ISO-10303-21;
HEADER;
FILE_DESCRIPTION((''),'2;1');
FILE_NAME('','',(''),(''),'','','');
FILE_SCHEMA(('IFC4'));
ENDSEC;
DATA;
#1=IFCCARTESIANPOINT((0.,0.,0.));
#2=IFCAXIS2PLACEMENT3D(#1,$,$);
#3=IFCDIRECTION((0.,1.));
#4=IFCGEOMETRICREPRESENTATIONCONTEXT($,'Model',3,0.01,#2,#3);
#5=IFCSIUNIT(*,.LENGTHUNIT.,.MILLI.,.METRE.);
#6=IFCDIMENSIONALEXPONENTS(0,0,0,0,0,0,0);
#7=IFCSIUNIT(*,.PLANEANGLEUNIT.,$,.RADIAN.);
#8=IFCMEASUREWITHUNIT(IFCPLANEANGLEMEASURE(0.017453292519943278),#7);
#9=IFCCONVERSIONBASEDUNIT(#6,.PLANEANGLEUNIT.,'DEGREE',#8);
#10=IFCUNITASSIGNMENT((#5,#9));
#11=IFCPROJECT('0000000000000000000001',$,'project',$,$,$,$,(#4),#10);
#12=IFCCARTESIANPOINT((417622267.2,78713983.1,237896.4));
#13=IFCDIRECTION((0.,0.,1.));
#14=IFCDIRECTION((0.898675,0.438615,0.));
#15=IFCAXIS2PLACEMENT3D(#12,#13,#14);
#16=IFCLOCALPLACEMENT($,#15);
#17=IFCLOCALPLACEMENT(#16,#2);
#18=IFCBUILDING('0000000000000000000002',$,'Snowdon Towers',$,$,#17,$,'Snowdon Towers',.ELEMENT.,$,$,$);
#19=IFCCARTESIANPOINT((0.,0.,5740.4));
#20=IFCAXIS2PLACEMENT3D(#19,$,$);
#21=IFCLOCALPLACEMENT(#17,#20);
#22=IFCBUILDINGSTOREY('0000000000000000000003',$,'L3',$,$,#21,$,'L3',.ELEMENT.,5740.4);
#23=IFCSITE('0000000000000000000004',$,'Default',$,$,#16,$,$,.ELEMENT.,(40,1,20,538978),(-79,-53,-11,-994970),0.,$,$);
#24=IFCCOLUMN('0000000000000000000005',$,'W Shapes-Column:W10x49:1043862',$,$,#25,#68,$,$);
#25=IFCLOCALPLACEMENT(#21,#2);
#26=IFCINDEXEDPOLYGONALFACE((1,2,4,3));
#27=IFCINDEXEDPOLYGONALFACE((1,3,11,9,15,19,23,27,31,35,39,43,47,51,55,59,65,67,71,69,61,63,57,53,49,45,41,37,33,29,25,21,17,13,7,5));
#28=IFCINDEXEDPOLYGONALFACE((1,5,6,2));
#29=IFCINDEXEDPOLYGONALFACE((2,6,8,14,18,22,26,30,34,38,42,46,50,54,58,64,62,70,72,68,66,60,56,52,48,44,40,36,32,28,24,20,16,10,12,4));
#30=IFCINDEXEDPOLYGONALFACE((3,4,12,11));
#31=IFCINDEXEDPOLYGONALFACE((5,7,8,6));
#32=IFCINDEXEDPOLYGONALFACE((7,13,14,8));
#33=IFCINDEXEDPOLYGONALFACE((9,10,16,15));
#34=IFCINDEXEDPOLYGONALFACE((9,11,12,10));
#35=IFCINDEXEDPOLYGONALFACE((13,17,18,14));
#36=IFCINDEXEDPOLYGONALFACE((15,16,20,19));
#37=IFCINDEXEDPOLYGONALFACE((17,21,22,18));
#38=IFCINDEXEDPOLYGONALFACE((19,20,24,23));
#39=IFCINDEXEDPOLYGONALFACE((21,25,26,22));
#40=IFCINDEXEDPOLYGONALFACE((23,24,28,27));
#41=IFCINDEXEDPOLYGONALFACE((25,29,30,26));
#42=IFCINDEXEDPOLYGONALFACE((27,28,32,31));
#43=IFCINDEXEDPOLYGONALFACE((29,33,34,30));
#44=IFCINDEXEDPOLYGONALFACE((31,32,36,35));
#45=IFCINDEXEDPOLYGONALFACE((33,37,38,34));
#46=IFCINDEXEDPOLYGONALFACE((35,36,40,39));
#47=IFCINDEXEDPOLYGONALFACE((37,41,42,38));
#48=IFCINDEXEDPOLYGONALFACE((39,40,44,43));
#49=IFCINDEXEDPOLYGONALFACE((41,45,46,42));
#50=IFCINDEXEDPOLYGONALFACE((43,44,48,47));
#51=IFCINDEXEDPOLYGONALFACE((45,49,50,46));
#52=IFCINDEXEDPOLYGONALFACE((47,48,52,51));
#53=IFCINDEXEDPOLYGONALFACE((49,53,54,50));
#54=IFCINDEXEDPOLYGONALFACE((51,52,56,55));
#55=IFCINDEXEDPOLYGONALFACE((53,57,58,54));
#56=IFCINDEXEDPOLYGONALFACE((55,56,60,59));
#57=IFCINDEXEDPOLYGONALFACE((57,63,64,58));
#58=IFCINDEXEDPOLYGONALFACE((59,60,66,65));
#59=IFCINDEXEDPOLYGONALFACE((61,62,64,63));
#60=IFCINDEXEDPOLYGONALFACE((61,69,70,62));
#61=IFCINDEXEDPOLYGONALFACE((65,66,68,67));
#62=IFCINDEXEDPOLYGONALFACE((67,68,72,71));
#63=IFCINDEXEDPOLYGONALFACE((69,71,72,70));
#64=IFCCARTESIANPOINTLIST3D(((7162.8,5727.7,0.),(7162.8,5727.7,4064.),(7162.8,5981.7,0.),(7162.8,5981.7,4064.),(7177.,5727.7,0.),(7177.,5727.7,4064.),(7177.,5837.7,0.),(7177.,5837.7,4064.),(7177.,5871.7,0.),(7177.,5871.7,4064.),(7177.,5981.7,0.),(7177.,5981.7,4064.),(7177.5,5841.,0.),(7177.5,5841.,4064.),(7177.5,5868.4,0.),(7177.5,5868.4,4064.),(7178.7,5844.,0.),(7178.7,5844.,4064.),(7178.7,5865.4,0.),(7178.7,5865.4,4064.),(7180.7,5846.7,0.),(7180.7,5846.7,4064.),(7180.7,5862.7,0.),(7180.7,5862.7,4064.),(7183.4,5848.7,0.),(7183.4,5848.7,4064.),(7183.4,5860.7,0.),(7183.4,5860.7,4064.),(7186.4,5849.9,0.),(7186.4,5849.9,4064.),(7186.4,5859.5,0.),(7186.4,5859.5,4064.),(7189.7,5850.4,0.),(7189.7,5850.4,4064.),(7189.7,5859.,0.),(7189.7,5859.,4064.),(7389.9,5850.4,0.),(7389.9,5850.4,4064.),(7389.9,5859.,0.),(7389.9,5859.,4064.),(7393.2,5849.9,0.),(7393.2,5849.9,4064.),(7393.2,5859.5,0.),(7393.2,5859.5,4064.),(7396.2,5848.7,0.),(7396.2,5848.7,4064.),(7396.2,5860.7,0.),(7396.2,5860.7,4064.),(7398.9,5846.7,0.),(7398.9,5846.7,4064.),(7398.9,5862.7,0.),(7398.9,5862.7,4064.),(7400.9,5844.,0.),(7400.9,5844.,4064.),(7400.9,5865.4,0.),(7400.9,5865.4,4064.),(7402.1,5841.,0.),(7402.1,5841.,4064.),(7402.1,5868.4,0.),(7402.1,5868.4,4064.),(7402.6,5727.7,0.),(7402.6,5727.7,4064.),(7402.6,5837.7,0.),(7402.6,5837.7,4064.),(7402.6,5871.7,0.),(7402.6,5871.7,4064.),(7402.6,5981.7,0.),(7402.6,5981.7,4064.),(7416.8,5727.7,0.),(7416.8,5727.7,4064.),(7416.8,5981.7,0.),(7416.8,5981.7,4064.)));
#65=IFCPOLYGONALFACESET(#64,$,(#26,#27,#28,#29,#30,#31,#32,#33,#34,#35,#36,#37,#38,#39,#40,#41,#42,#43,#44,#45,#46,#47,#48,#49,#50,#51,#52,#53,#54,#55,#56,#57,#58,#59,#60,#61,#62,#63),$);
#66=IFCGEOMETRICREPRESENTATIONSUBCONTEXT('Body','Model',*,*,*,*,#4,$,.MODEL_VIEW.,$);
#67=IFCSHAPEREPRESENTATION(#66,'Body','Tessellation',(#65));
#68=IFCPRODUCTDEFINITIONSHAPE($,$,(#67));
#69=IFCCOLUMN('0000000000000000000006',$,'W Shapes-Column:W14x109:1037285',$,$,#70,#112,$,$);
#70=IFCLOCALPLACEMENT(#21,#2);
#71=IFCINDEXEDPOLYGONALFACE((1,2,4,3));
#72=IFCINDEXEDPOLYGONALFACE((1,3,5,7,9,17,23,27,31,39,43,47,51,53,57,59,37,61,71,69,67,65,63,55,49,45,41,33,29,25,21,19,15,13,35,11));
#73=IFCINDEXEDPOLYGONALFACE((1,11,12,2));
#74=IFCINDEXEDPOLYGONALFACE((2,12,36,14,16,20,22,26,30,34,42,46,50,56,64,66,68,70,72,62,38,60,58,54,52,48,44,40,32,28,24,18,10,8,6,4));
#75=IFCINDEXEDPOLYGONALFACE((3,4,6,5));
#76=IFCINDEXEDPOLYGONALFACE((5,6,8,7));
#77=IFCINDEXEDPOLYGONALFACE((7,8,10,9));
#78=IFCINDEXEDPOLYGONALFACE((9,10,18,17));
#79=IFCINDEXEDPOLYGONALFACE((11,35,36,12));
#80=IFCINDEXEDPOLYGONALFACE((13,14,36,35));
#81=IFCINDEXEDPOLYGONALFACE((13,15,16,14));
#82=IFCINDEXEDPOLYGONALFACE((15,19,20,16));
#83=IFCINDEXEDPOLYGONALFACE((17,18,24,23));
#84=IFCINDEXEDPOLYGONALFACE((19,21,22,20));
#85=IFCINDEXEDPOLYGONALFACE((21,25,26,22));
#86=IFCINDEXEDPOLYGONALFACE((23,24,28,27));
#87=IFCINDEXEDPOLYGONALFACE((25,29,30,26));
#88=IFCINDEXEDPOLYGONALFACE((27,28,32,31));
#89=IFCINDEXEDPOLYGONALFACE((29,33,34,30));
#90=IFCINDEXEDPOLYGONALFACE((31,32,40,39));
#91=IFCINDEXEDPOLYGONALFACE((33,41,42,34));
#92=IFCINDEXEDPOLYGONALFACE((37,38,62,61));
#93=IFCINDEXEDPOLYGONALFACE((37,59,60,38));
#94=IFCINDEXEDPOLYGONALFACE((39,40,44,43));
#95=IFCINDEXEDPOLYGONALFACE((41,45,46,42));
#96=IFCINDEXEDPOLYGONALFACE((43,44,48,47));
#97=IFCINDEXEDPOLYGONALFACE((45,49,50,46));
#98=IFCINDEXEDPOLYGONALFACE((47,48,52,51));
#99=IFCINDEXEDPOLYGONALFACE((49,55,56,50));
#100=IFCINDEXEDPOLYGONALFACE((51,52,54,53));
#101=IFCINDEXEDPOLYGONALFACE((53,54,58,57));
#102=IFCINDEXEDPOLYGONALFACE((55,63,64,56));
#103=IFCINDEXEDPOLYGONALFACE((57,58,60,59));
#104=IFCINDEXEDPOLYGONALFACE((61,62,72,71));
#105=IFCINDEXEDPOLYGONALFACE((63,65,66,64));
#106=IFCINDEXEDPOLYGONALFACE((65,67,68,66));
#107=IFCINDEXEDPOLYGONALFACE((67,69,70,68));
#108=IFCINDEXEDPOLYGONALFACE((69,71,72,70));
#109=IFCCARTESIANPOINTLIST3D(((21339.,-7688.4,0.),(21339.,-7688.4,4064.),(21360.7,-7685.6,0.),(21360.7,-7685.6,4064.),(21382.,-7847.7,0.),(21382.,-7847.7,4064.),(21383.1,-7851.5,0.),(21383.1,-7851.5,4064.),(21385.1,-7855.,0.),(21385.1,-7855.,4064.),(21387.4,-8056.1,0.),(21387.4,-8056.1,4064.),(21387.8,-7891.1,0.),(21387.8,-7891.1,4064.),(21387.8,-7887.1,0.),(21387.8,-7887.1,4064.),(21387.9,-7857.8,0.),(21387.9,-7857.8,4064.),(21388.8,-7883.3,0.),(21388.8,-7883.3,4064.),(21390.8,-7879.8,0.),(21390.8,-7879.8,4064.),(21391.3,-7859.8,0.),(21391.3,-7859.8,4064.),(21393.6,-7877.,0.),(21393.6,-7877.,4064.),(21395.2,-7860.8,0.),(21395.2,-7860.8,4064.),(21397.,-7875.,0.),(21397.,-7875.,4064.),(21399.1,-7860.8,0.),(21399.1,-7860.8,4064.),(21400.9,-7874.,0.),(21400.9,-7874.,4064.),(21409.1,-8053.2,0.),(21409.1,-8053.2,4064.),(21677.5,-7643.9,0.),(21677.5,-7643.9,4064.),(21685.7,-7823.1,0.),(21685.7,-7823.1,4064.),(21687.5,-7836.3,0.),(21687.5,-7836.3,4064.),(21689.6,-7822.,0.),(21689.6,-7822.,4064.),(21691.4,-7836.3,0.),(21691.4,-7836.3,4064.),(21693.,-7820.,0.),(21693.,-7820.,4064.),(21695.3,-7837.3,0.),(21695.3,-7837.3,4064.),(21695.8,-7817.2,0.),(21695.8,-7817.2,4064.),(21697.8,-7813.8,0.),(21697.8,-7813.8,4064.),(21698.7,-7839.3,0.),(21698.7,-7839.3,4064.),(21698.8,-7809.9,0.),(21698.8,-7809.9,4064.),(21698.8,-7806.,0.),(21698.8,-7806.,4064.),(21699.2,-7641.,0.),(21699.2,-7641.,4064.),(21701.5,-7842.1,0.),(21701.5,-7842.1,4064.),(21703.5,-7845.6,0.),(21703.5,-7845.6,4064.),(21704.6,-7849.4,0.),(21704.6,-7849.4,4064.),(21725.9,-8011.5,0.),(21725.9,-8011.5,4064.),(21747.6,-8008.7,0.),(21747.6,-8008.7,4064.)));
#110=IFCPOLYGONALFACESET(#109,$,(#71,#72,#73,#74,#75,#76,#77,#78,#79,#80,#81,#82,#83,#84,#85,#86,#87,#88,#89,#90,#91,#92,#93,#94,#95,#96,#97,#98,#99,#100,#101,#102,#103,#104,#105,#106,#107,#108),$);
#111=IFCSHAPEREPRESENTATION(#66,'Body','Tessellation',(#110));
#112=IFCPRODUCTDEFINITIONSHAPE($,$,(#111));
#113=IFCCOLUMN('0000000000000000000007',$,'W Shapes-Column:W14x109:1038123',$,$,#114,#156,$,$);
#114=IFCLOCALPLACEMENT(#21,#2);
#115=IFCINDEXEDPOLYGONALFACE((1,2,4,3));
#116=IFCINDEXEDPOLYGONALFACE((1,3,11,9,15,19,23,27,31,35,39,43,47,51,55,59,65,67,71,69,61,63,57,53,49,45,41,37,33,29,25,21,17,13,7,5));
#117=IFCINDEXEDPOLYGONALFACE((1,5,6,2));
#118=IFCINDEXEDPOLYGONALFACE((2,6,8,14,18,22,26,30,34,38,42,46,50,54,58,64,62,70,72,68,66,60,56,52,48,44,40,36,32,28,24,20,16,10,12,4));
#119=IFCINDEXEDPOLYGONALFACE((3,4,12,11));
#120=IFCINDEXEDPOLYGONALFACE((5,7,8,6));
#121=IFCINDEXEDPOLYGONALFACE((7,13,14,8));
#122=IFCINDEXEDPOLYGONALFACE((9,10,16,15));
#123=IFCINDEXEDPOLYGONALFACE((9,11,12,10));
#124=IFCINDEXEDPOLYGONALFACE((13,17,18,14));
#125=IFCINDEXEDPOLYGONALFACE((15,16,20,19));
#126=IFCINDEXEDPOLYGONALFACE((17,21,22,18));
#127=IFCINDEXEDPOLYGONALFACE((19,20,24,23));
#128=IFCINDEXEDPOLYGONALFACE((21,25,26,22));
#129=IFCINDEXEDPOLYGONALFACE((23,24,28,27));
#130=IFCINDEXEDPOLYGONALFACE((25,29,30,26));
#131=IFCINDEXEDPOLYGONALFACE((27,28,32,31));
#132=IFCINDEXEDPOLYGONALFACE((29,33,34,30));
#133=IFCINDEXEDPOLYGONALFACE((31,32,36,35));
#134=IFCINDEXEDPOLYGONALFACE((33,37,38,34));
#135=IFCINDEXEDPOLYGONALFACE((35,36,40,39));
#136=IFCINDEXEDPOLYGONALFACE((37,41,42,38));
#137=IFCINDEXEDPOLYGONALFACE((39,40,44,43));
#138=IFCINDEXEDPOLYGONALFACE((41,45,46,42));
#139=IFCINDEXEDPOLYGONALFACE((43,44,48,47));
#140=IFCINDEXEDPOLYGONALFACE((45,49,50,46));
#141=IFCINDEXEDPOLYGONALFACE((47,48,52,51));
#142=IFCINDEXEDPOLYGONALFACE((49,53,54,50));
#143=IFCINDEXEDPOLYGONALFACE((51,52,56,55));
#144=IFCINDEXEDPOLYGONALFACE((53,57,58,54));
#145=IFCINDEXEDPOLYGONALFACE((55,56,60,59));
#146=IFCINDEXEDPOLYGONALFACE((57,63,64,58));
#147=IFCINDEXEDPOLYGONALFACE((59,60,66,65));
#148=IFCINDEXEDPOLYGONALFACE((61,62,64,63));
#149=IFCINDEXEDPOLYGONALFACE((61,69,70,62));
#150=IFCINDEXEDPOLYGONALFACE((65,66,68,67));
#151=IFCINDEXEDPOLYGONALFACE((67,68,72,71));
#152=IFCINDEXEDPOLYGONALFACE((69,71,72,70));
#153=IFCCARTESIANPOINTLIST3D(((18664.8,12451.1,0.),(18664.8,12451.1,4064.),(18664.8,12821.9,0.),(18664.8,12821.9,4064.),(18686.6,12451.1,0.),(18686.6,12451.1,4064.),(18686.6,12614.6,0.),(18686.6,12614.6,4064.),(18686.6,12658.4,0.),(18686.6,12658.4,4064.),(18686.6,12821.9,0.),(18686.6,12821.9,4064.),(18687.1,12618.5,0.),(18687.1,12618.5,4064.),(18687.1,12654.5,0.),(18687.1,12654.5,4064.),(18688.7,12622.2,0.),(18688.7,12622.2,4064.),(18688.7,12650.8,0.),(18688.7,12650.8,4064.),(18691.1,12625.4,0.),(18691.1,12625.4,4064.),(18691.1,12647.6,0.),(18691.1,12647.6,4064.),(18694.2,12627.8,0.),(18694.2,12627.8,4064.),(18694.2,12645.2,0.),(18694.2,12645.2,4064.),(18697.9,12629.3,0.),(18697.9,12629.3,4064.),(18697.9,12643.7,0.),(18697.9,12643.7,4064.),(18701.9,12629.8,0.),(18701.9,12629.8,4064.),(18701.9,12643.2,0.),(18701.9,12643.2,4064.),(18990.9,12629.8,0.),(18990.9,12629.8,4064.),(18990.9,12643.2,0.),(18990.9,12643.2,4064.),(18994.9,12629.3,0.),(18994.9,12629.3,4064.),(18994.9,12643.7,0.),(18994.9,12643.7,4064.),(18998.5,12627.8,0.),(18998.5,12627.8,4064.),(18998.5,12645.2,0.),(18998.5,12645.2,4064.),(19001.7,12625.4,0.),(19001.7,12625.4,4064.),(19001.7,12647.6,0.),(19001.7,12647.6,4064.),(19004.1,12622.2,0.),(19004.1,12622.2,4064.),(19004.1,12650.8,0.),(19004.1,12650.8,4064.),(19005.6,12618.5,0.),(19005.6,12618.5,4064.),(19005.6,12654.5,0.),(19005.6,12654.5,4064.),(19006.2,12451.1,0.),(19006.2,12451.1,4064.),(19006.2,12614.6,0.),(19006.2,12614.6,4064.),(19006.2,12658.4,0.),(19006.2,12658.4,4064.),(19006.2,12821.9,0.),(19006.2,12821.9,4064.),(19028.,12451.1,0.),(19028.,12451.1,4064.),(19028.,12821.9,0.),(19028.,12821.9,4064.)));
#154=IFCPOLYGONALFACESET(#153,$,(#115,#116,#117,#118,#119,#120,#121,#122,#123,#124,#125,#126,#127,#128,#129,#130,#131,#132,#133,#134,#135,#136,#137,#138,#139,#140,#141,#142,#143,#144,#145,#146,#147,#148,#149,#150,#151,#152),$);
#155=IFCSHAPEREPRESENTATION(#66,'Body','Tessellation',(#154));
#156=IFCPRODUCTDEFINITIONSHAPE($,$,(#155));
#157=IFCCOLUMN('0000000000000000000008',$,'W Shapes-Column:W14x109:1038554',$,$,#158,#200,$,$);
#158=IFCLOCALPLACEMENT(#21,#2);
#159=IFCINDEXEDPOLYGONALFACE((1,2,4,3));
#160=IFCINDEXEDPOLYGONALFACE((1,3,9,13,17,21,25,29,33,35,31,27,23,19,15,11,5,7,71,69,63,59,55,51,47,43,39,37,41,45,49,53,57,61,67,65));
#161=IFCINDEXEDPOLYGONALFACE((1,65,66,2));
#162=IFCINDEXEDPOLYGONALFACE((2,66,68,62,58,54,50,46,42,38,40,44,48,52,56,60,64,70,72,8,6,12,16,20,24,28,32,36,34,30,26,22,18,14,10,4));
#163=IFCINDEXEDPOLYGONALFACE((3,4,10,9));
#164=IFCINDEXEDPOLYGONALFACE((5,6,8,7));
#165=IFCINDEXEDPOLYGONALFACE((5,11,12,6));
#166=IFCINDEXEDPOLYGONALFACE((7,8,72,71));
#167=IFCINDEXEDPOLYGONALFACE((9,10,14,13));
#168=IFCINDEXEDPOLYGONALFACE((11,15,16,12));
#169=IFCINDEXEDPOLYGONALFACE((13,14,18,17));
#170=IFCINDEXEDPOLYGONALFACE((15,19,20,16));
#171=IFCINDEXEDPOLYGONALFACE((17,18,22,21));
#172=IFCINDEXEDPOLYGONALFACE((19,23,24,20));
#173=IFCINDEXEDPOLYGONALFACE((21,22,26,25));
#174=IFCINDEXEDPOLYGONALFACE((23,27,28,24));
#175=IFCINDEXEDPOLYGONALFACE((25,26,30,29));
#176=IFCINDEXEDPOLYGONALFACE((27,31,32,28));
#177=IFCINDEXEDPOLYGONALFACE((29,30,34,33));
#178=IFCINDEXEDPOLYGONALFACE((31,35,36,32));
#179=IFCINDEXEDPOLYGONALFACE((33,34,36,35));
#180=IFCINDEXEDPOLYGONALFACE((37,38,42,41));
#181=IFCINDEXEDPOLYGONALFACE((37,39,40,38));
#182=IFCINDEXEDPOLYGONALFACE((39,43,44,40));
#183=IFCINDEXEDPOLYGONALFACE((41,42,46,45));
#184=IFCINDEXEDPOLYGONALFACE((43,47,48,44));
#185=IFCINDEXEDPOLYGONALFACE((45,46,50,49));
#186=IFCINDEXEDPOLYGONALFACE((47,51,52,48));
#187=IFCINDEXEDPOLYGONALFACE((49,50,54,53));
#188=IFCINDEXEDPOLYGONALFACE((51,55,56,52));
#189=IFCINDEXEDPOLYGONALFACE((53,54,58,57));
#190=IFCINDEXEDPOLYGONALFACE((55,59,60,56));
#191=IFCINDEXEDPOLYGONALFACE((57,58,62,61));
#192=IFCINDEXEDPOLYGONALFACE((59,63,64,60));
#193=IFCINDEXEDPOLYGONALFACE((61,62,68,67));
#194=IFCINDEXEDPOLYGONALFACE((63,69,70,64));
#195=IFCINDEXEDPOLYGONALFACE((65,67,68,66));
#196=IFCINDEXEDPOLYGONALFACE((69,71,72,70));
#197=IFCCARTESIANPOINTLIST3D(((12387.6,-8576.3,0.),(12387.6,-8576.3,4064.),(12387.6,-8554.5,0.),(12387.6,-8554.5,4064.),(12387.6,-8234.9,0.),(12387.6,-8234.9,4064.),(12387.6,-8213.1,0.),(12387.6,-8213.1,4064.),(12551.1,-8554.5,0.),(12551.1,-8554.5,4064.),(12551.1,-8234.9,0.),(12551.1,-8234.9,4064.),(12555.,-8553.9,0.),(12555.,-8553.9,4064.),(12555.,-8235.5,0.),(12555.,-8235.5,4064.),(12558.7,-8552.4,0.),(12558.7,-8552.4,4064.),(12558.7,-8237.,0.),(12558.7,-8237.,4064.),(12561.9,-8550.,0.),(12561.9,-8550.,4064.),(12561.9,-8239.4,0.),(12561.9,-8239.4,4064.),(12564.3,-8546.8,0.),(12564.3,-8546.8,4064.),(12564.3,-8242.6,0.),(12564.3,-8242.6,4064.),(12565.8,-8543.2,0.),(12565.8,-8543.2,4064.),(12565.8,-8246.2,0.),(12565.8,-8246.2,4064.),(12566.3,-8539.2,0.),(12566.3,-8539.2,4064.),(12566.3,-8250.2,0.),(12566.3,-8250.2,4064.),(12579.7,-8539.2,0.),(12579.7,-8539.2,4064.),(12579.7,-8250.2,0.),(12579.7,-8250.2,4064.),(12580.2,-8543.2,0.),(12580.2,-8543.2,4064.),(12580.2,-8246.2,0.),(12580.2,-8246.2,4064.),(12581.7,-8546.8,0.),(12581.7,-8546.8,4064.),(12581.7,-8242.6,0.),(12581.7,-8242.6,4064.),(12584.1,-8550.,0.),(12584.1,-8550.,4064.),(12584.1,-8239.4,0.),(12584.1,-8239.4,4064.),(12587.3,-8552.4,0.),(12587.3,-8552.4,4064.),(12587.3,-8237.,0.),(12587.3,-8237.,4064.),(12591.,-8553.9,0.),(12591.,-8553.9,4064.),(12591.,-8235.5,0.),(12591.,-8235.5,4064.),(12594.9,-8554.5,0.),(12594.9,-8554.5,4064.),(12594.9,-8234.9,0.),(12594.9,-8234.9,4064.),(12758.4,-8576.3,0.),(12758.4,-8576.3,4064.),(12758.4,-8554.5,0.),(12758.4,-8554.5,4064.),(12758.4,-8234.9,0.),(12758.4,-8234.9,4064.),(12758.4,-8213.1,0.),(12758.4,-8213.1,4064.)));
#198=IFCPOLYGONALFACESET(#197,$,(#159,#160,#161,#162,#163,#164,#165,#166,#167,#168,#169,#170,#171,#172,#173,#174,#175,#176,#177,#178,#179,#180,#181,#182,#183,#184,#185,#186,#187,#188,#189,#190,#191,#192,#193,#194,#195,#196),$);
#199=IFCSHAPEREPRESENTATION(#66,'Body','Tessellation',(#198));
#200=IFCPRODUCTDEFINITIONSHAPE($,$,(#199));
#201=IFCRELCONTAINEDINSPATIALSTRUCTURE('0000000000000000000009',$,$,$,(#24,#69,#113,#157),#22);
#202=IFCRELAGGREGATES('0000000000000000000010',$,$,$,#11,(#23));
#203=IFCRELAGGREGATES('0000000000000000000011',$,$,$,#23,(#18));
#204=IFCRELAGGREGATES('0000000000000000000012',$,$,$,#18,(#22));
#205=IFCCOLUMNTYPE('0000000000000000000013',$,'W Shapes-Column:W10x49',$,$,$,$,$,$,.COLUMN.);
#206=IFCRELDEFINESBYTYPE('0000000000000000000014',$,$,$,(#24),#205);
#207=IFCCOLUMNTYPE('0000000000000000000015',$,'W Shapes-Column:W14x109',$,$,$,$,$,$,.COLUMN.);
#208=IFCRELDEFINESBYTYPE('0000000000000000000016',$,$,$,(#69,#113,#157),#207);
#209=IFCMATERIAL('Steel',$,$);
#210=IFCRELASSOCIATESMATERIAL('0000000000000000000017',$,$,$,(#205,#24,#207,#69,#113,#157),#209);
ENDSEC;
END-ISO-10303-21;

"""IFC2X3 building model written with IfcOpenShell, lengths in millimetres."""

from ifc_helpers import new_model, entity, si_unit, converted_unit, direction, frame, frame_2d, origin, place, context, subcontext, project, spatial, i_section, extrude, source, transform, mapped, material, type_object, type_shapes, element, save


model = new_model("IFC2X3")

# Units and contexts
model_context = context("Model", 3, precision=0.01, world=origin(), true_north=direction((0.0, 1.0)))
body_context = subcontext(model_context, "Body", "Model", "MODEL_VIEW")
ifc_project = project(units=[si_unit("LENGTHUNIT", "METRE", prefix="MILLI"), converted_unit("PLANEANGLEUNIT", "DEGREE", entity("IfcPlaneAngleMeasure", 0.017453292519943278), si_unit("PLANEANGLEUNIT", "RADIAN"), dimensions=[0, 0, 0, 0, 0, 0, 0])], contexts=[model_context])

# Site, building, storey
site_placement = place(None, frame((417622267.2, 78713983.1, 237896.4), z_axis=(0.0, 0.0, 1.0), x_axis=(0.898675, 0.438615, 0.0)))
site = spatial("IfcSite", under=ifc_project, at=site_placement, Name="Default", CompositionType="ELEMENT", RefLatitude=(40, 1, 20, 538978), RefLongitude=(-79, -53, -11, -994970), RefElevation=0.0)
building_placement = place(site_placement, origin())
building = spatial("IfcBuilding", under=site, at=building_placement, Name="Snowdon Towers", LongName="Snowdon Towers", CompositionType="ELEMENT")
storey_placement = place(building_placement, frame((0.0, 0.0, 5740.4)))
storey = spatial("IfcBuildingStorey", under=building, at=storey_placement, Name="L3", LongName="L3", CompositionType="ELEMENT", Elevation=5740.4)

# Columns
ifc_material_1 = material(Name="Steel")
column_type_1 = type_object("IfcColumnType", Name="W Shapes-Column:W10x49", PredefinedType="COLUMN", material=ifc_material_1)
shared_shape_1 = source(origin(), body_context, "Body", "SweptSolid", [
    extrude(i_section(OverallWidth=254.0, OverallDepth=254.0, WebThickness=8.6, FlangeThickness=14.2, FilletRadius=12.7, at=frame_2d((0.0, 0.0), x_axis=(1.0, 0.0))), frame((0.0, 0.0, 5740.4), z_axis=(0.0, 0.0, 1.0), x_axis=(-1.0, 0.0, 0.0)), (0.0, 0.0, 1.0), 4064.0),
])
type_shapes(column_type_1, [shared_shape_1])
for number, where, z_axis, x_axis, name in (
    (1, (7289.8, 5854.7, -5740.4), (0.0, 0.0, 1.0), (0.0, 1.0, 0.0), "W Shapes-Column:W10x49:1043862"),
):
    element("IfcColumn", number, at=place(storey_placement, frame(where, z_axis=z_axis, x_axis=x_axis)), inside=storey, type_object=column_type_1, material=ifc_material_1, Name=name, context=body_context, shape_type="MappedRepresentation", body=[
        mapped(shared_shape_1, transform((0.0, 0.0, 0.0), scale=1.0)),
    ])
column_type_2 = type_object("IfcColumnType", Name="W Shapes-Column:W14x109", PredefinedType="COLUMN", material=ifc_material_1)
shared_shape_2 = source(origin(), body_context, "Body", "SweptSolid", [
    extrude(i_section(OverallWidth=370.8, OverallDepth=363.2, WebThickness=13.3, FlangeThickness=21.8, FilletRadius=15.2, at=frame_2d((0.0, 0.0), x_axis=(1.0, 0.0))), frame((0.0, 0.0, 5740.4), z_axis=(0.0, 0.0, 1.0), x_axis=(-1.0, 0.0, 0.0)), (0.0, 0.0, 1.0), 4064.0),
])
type_shapes(column_type_2, [shared_shape_2])
for number, where, z_axis, x_axis, name in (
    (2, (21543.3, -7848.5, -5740.4), (0.0, 0.0, 1.0), (-0.130526, 0.991445, 0.0), "W Shapes-Column:W14x109:1037285"),
    (3, (18846.4, 12636.5, -5740.4), (0.0, 0.0, 1.0), (0.0, 1.0, 0.0), "W Shapes-Column:W14x109:1038123"),
    (4, (12573.0, -8394.7, -5740.4), (0.0, 0.0, 1.0), (-1.0, 0.0, 0.0), "W Shapes-Column:W14x109:1038554"),
):
    element("IfcColumn", number, at=place(storey_placement, frame(where, z_axis=z_axis, x_axis=x_axis)), inside=storey, type_object=column_type_2, material=ifc_material_1, Name=name, context=body_context, shape_type="MappedRepresentation", body=[
        mapped(shared_shape_2, transform((0.0, 0.0, 0.0), scale=1.0)),
    ])

save(model, "model.ifc")
